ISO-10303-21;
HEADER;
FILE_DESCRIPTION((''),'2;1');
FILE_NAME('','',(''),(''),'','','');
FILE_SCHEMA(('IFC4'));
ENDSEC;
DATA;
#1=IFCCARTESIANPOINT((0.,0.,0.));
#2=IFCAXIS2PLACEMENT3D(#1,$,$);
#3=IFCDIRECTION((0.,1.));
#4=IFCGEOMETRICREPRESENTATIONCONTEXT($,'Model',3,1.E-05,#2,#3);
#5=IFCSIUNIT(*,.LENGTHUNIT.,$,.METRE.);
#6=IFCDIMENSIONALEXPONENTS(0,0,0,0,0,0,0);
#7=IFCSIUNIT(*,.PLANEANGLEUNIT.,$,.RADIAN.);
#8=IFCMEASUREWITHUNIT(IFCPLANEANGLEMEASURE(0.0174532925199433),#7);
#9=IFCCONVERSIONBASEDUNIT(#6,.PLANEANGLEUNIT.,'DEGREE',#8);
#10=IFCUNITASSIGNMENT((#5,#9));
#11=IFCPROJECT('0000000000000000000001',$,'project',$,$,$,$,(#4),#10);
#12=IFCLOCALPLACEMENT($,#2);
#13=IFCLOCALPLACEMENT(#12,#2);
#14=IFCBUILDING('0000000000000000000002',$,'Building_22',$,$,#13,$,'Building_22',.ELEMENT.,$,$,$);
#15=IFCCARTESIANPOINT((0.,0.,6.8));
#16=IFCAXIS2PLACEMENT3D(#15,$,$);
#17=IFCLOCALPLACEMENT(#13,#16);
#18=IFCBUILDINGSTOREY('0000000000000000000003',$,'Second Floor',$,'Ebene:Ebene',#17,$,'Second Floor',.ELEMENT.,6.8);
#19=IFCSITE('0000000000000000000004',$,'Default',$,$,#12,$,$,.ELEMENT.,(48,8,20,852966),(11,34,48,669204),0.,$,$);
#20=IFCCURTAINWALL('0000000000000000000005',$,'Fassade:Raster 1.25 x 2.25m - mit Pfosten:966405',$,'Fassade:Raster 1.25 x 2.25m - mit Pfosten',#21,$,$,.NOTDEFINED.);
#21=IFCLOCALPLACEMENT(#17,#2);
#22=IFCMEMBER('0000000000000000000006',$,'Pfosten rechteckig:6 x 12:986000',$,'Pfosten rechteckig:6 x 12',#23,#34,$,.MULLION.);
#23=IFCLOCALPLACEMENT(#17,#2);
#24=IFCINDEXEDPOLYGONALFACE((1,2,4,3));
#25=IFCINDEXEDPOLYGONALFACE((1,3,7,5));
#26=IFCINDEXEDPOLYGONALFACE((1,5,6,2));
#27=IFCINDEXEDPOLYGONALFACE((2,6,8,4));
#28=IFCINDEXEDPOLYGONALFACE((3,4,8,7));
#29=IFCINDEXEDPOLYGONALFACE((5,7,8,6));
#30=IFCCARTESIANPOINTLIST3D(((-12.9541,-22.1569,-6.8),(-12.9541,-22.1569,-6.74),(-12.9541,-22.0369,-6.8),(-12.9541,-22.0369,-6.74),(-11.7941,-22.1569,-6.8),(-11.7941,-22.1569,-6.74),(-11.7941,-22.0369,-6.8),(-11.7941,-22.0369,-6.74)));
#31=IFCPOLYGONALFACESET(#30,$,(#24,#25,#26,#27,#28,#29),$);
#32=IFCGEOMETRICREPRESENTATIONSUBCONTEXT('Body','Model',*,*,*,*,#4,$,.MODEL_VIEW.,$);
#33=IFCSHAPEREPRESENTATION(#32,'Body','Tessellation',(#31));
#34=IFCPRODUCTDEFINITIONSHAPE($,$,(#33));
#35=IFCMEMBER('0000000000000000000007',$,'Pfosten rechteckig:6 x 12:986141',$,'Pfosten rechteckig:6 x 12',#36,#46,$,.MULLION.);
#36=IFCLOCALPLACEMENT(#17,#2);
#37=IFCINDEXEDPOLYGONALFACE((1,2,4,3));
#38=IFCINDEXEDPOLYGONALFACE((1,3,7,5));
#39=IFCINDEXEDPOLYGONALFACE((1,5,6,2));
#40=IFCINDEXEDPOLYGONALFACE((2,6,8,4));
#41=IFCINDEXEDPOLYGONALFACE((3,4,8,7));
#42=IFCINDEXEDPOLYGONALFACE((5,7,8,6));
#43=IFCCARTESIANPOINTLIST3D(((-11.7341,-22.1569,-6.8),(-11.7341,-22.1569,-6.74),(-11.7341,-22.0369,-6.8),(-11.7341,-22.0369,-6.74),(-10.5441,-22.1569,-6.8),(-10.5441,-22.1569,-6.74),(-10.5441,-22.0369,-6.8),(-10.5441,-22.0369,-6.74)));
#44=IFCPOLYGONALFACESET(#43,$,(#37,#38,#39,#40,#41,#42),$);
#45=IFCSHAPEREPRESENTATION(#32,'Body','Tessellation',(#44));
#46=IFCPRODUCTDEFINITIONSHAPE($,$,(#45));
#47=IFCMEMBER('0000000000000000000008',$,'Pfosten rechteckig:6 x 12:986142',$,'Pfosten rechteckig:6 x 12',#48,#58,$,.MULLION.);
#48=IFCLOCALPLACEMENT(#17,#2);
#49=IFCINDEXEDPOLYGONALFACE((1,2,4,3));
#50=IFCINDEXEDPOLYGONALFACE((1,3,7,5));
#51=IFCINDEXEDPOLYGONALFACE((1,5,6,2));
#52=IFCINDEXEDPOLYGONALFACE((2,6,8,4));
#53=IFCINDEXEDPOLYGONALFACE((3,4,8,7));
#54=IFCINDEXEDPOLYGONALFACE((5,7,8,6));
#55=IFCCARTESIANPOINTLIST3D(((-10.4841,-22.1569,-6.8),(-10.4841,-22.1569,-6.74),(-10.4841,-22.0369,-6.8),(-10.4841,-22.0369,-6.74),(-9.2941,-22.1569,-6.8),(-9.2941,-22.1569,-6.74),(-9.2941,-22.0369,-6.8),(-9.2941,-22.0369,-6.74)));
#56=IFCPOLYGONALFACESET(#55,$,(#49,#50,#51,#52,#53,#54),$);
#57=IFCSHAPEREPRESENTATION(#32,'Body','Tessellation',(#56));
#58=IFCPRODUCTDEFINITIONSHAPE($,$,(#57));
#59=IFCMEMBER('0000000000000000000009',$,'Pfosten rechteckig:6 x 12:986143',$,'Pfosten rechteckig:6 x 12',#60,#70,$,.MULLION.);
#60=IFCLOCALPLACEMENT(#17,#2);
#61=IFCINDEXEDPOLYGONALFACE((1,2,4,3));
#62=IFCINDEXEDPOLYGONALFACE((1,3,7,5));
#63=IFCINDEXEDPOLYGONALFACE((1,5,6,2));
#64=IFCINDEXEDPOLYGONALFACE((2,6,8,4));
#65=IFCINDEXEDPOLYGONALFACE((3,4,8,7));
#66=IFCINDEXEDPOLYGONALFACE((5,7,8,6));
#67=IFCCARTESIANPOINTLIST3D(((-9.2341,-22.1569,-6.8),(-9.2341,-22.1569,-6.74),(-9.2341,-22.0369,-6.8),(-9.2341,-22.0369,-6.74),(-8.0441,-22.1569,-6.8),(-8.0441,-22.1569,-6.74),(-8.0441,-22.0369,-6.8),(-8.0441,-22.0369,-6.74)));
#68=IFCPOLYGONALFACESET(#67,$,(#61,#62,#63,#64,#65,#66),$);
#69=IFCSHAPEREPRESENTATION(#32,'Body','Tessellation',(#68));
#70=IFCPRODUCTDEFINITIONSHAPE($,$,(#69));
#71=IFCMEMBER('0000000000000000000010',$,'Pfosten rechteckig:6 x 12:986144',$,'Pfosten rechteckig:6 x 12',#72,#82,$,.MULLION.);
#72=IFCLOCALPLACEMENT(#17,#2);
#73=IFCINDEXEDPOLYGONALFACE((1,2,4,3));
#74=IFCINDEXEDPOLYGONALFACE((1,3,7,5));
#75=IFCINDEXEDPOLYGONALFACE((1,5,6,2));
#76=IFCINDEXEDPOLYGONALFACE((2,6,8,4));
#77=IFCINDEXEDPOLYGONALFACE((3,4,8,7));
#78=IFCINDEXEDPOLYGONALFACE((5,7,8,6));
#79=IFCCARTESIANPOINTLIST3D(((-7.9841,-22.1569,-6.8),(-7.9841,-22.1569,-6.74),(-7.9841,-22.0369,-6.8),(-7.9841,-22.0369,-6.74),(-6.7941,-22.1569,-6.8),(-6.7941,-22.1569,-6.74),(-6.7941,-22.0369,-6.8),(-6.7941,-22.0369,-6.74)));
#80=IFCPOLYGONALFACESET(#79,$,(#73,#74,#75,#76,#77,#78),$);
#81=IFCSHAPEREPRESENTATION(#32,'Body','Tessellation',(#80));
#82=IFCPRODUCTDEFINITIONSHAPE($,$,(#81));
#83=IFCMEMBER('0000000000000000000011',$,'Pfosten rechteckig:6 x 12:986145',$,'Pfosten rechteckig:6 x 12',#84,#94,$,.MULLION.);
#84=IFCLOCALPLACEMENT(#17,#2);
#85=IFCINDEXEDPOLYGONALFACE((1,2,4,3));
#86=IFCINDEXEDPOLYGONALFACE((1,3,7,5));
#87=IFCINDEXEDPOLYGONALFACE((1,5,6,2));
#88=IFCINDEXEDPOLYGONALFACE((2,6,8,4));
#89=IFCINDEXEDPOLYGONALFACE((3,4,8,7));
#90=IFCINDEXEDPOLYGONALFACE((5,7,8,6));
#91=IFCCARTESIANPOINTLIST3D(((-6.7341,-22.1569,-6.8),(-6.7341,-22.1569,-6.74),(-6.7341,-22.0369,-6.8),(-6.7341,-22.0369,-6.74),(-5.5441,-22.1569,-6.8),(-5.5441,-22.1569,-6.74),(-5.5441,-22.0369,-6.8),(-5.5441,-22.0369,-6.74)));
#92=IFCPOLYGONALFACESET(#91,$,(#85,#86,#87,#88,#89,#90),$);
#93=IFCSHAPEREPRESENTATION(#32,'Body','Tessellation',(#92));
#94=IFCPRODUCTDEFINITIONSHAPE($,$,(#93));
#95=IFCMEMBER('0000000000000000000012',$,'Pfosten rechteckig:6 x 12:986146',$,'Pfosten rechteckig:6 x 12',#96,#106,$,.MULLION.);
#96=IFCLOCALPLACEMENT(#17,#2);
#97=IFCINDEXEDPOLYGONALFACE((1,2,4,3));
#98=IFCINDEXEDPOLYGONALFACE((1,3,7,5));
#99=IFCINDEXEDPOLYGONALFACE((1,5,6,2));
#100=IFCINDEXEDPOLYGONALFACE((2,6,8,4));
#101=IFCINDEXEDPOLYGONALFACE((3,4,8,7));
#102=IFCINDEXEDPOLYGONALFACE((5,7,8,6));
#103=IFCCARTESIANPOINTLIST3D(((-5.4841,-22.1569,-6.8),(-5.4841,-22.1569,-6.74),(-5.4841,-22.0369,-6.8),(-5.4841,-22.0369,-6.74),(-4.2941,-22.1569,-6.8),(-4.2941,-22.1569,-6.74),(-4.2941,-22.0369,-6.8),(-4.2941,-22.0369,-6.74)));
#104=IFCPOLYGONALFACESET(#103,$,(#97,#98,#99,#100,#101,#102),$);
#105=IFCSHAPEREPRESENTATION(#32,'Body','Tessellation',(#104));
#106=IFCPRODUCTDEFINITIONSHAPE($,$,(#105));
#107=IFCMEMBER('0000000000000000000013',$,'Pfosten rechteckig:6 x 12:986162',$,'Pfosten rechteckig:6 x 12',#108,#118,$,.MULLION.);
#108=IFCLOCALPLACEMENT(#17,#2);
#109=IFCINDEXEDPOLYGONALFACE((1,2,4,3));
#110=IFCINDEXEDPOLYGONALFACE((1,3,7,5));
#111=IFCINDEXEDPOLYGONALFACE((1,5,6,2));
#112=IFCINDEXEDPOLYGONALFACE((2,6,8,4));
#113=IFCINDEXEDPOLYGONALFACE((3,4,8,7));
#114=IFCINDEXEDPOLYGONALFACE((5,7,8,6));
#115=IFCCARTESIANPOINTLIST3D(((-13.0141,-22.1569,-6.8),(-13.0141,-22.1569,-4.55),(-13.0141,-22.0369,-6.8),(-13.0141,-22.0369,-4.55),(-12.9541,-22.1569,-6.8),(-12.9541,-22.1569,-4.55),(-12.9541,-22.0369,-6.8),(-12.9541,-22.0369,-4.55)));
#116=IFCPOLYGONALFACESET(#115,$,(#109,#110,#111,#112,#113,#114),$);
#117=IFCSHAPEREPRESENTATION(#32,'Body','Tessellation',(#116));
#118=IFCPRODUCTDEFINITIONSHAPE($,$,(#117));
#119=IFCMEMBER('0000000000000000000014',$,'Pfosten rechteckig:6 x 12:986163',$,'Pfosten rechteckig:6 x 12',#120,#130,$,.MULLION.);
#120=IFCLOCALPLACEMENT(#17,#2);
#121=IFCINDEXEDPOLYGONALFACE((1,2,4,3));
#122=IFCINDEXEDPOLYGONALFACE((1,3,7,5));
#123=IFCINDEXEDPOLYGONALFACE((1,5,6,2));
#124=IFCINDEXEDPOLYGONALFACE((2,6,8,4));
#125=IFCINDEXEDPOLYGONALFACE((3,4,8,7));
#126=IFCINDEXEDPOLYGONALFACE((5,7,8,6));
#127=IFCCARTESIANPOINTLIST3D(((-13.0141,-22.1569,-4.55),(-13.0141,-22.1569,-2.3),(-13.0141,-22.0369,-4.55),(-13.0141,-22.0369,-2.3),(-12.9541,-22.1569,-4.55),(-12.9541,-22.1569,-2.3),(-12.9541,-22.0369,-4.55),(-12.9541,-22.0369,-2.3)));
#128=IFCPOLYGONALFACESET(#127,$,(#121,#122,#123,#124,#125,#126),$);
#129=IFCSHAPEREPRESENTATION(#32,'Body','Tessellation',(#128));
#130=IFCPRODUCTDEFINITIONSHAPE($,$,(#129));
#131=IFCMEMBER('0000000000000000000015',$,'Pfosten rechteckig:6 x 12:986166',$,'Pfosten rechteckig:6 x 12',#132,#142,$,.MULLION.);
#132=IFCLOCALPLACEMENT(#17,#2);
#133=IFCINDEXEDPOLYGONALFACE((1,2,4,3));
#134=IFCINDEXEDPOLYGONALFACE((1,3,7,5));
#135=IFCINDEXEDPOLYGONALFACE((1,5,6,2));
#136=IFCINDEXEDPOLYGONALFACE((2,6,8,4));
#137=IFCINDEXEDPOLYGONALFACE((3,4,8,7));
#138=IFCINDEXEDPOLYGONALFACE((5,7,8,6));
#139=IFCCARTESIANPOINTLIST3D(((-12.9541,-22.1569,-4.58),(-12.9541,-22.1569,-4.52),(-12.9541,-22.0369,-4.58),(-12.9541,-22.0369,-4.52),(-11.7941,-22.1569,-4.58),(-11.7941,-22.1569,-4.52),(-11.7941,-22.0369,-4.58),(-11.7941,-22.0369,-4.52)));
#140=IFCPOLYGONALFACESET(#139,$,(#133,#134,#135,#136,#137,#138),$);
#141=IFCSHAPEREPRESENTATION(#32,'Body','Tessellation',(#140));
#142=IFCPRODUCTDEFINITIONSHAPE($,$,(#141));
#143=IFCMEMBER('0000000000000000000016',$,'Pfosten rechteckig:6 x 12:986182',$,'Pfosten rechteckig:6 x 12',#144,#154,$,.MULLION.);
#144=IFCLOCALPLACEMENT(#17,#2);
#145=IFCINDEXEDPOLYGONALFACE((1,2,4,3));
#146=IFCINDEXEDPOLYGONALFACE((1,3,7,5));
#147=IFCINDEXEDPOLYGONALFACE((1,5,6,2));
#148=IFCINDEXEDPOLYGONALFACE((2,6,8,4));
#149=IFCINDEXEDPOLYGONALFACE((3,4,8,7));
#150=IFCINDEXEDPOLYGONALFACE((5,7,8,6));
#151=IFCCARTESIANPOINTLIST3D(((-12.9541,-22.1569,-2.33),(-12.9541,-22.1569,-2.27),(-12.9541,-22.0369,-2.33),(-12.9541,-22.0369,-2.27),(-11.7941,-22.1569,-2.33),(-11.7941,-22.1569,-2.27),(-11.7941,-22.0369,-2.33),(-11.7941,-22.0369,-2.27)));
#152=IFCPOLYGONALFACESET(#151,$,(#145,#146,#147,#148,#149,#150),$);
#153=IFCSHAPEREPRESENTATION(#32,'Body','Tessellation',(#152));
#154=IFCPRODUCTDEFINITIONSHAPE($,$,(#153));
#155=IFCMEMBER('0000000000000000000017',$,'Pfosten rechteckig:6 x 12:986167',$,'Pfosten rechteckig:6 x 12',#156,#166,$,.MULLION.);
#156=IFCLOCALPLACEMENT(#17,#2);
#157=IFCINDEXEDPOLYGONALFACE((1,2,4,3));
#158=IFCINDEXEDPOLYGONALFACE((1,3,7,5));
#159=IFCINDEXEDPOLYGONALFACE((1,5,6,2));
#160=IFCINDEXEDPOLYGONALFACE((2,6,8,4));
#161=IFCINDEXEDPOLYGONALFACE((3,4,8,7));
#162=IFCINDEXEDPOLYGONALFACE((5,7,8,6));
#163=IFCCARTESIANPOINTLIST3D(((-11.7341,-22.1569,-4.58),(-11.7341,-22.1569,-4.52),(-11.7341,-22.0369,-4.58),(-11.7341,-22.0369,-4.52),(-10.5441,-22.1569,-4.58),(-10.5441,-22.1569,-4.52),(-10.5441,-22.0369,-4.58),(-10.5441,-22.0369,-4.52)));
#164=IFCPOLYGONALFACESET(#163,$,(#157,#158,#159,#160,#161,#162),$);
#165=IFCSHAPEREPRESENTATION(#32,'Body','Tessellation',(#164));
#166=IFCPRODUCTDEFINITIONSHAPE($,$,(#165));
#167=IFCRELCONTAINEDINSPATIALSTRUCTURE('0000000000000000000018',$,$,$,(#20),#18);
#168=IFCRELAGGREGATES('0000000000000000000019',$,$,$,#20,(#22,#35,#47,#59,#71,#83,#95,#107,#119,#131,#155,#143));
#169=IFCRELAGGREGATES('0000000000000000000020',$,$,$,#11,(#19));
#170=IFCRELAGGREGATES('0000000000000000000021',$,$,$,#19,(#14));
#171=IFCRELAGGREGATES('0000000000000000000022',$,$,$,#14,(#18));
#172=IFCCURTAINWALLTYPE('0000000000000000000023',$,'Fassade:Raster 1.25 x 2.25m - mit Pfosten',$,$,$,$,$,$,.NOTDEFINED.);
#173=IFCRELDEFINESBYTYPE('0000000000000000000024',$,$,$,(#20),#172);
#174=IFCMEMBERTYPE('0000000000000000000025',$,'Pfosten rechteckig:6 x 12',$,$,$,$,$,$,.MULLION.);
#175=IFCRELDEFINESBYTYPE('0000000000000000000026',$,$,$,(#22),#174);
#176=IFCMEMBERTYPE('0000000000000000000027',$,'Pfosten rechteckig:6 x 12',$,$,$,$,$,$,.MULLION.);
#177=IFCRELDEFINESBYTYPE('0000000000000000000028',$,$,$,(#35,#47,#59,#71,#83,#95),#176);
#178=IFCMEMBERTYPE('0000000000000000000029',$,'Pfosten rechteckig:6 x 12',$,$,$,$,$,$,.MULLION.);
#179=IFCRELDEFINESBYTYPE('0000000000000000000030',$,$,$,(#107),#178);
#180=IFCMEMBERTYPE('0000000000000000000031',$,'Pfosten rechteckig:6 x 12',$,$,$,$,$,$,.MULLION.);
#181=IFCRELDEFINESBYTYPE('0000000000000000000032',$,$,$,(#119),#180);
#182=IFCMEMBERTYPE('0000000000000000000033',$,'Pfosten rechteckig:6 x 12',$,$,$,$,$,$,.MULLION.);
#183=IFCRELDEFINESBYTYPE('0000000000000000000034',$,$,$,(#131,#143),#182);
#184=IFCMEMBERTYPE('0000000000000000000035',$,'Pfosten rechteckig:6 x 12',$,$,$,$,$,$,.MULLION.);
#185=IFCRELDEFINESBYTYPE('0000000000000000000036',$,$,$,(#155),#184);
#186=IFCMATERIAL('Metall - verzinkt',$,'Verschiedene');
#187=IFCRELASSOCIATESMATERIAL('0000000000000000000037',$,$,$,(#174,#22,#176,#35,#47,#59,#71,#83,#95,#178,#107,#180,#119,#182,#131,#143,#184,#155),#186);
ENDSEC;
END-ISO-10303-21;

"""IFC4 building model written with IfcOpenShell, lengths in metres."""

from ifc_helpers import new_model, entity, si_unit, converted_unit, direction, frame, origin, place, context, subcontext, project, spatial, indexed_curve, outline, extrude, source, transform, mapped, material, type_object, type_shapes, element, aggregate, save


model = new_model("IFC4")

# Units and contexts
model_context = context("Model", 3, precision=1e-05, world=origin(), true_north=direction((0.0, 1.0)))
body_context = subcontext(model_context, "Body", "Model", "MODEL_VIEW")
ifc_project = project(units=[si_unit("LENGTHUNIT", "METRE"), converted_unit("PLANEANGLEUNIT", "DEGREE", entity("IfcPlaneAngleMeasure", 0.0174532925199433), si_unit("PLANEANGLEUNIT", "RADIAN"), dimensions=[0, 0, 0, 0, 0, 0, 0])], contexts=[model_context])

# Site, building, storey
site_placement = place(None, origin())
site = spatial("IfcSite", under=ifc_project, at=site_placement, Name="Default", CompositionType="ELEMENT", RefLatitude=(48, 8, 20, 852966), RefLongitude=(11, 34, 48, 669204), RefElevation=0.0)
building_placement = place(site_placement, origin())
building = spatial("IfcBuilding", under=site, at=building_placement, Name="Building_22", LongName="Building_22", CompositionType="ELEMENT")
storey_placement = place(building_placement, frame((0.0, 0.0, 6.8)))
storey = spatial("IfcBuildingStorey", under=building, at=storey_placement, Name="Second Floor", ObjectType="Ebene:Ebene", LongName="Second Floor", CompositionType="ELEMENT", Elevation=6.8)

# Curtain wall, members
curtain_wall_type = type_object("IfcCurtainWallType", Name="Fassade:Raster 1.25 x 2.25m - mit Pfosten", PredefinedType="NOTDEFINED")
curtain_wall_placement = place(storey_placement, frame((0.0, 0.0, -6.8)))
curtain_wall = element("IfcCurtainWall", 1, at=curtain_wall_placement, inside=storey, type_object=curtain_wall_type, Name="Fassade:Raster 1.25 x 2.25m - mit Pfosten:966405", ObjectType="Fassade:Raster 1.25 x 2.25m - mit Pfosten", PredefinedType="NOTDEFINED")
ifc_material_1 = material(Name="Metall - verzinkt", Category="Verschiedene")
member_type_1 = type_object("IfcMemberType", Name="Pfosten rechteckig:6 x 12", PredefinedType="MULLION", material=ifc_material_1)
shared_shape_1 = source(origin(), body_context, "Body", "SweptSolid", [
    extrude(outline(indexed_curve([(-0.03, -0.06), (0.03, -0.06), (0.03, 0.06), (-0.03, 0.06), (-0.03, -0.06)], self_intersect=False)), frame((-0.03, 0.0, -1.16), z_axis=(0.0, 0.0, 1.0), x_axis=(-1.0, 0.0, 0.0)), (0.0, 0.0, 1.0), 1.16),
])
type_shapes(member_type_1, [shared_shape_1])
member_1_placement = place(curtain_wall_placement, frame((-12.9541, -22.0969, 0.0), z_axis=(-1.0, 0.0, 0.0), x_axis=(0.0, 0.0, -1.0)))
member_1 = element("IfcMember", 2, at=member_1_placement, type_object=member_type_1, material=ifc_material_1, Name="Pfosten rechteckig:6 x 12:986000", ObjectType="Pfosten rechteckig:6 x 12", PredefinedType="MULLION", context=body_context, shape_type="MappedRepresentation", body=[
    mapped(shared_shape_1, transform((0.0, 0.0, 0.0), scale=1.0)),
])
member_type_2 = type_object("IfcMemberType", Name="Pfosten rechteckig:6 x 12", PredefinedType="MULLION", material=ifc_material_1)
shared_shape_2 = source(origin(), body_context, "Body", "SweptSolid", [
    extrude(outline(indexed_curve([(-0.03, -0.06), (0.03, -0.06), (0.03, 0.06), (-0.03, 0.06), (-0.03, -0.06)], self_intersect=False)), frame((-0.03, 0.0, -1.19), z_axis=(0.0, 0.0, 1.0), x_axis=(-1.0, 0.0, 0.0)), (0.0, 0.0, 1.0), 1.19),
])
type_shapes(member_type_2, [shared_shape_2])
member_2_placement = place(curtain_wall_placement, frame((-11.7341, -22.0969, 0.0), z_axis=(-1.0, 0.0, 0.0), x_axis=(0.0, 0.0, -1.0)))
member_2 = element("IfcMember", 3, at=member_2_placement, type_object=member_type_2, material=ifc_material_1, Name="Pfosten rechteckig:6 x 12:986141", ObjectType="Pfosten rechteckig:6 x 12", PredefinedType="MULLION", context=body_context, shape_type="MappedRepresentation", body=[
    mapped(shared_shape_2, transform((0.0, 0.0, 0.0), scale=1.0)),
])
member_3_placement = place(curtain_wall_placement, frame((-10.4841, -22.0969, 0.0), z_axis=(-1.0, 0.0, 0.0), x_axis=(0.0, 0.0, -1.0)))
member_3 = element("IfcMember", 4, at=member_3_placement, type_object=member_type_2, material=ifc_material_1, Name="Pfosten rechteckig:6 x 12:986142", ObjectType="Pfosten rechteckig:6 x 12", PredefinedType="MULLION", context=body_context, shape_type="MappedRepresentation", body=[
    mapped(shared_shape_2, transform((0.0, 0.0, 0.0), scale=1.0)),
])
member_4_placement = place(curtain_wall_placement, frame((-9.2341, -22.0969, 0.0), z_axis=(-1.0, 0.0, 0.0), x_axis=(0.0, 0.0, -1.0)))
member_4 = element("IfcMember", 5, at=member_4_placement, type_object=member_type_2, material=ifc_material_1, Name="Pfosten rechteckig:6 x 12:986143", ObjectType="Pfosten rechteckig:6 x 12", PredefinedType="MULLION", context=body_context, shape_type="MappedRepresentation", body=[
    mapped(shared_shape_2, transform((0.0, 0.0, 0.0), scale=1.0)),
])
member_5_placement = place(curtain_wall_placement, frame((-7.9841, -22.0969, 0.0), z_axis=(-1.0, 0.0, 0.0), x_axis=(0.0, 0.0, -1.0)))
member_5 = element("IfcMember", 6, at=member_5_placement, type_object=member_type_2, material=ifc_material_1, Name="Pfosten rechteckig:6 x 12:986144", ObjectType="Pfosten rechteckig:6 x 12", PredefinedType="MULLION", context=body_context, shape_type="MappedRepresentation", body=[
    mapped(shared_shape_2, transform((0.0, 0.0, 0.0), scale=1.0)),
])
member_6_placement = place(curtain_wall_placement, frame((-6.7341, -22.0969, 0.0), z_axis=(-1.0, 0.0, 0.0), x_axis=(0.0, 0.0, -1.0)))
member_6 = element("IfcMember", 7, at=member_6_placement, type_object=member_type_2, material=ifc_material_1, Name="Pfosten rechteckig:6 x 12:986145", ObjectType="Pfosten rechteckig:6 x 12", PredefinedType="MULLION", context=body_context, shape_type="MappedRepresentation", body=[
    mapped(shared_shape_2, transform((0.0, 0.0, 0.0), scale=1.0)),
])
member_7_placement = place(curtain_wall_placement, frame((-5.4841, -22.0969, 0.0), z_axis=(-1.0, 0.0, 0.0), x_axis=(0.0, 0.0, -1.0)))
member_7 = element("IfcMember", 8, at=member_7_placement, type_object=member_type_2, material=ifc_material_1, Name="Pfosten rechteckig:6 x 12:986146", ObjectType="Pfosten rechteckig:6 x 12", PredefinedType="MULLION", context=body_context, shape_type="MappedRepresentation", body=[
    mapped(shared_shape_2, transform((0.0, 0.0, 0.0), scale=1.0)),
])
member_type_3 = type_object("IfcMemberType", Name="Pfosten rechteckig:6 x 12", PredefinedType="MULLION", material=ifc_material_1)
shared_shape_3 = source(origin(), body_context, "Body", "SweptSolid", [
    extrude(outline(indexed_curve([(-0.03, -0.06), (0.03, -0.06), (0.03, 0.06), (-0.03, 0.06), (-0.03, -0.06)], self_intersect=False)), frame((-0.03, 0.0, -2.25), z_axis=(0.0, 0.0, 1.0), x_axis=(-1.0, 0.0, 0.0)), (0.0, 0.0, 1.0), 2.25),
])
type_shapes(member_type_3, [shared_shape_3])
member_8_placement = place(curtain_wall_placement, frame((-13.0141, -22.0969, 2.25), z_axis=(0.0, 0.0, 1.0), x_axis=(-1.0, 0.0, 0.0)))
member_8 = element("IfcMember", 9, at=member_8_placement, type_object=member_type_3, material=ifc_material_1, Name="Pfosten rechteckig:6 x 12:986162", ObjectType="Pfosten rechteckig:6 x 12", PredefinedType="MULLION", context=body_context, shape_type="MappedRepresentation", body=[
    mapped(shared_shape_3, transform((0.0, 0.0, 0.0), scale=1.0)),
])
member_type_4 = type_object("IfcMemberType", Name="Pfosten rechteckig:6 x 12", PredefinedType="MULLION", material=ifc_material_1)
shared_shape_4 = source(origin(), body_context, "Body", "SweptSolid", [
    extrude(outline(indexed_curve([(-0.03, -0.06), (0.03, -0.06), (0.03, 0.06), (-0.03, 0.06), (-0.03, -0.06)], self_intersect=False)), frame((-0.03, 0.0, -2.25), z_axis=(0.0, 0.0, 1.0), x_axis=(-1.0, 0.0, 0.0)), (0.0, 0.0, 1.0), 2.25),
])
type_shapes(member_type_4, [shared_shape_4])
member_9_placement = place(curtain_wall_placement, frame((-13.0141, -22.0969, 4.5), z_axis=(0.0, 0.0, 1.0), x_axis=(-1.0, 0.0, 0.0)))
member_9 = element("IfcMember", 10, at=member_9_placement, type_object=member_type_4, material=ifc_material_1, Name="Pfosten rechteckig:6 x 12:986163", ObjectType="Pfosten rechteckig:6 x 12", PredefinedType="MULLION", context=body_context, shape_type="MappedRepresentation", body=[
    mapped(shared_shape_4, transform((0.0, 0.0, 0.0), scale=1.0)),
])
member_type_5 = type_object("IfcMemberType", Name="Pfosten rechteckig:6 x 12", PredefinedType="MULLION", material=ifc_material_1)
shared_shape_5 = source(origin(), body_context, "Body", "SweptSolid", [
    extrude(outline(indexed_curve([(-0.03, -0.06), (0.03, -0.06), (0.03, 0.06), (-0.03, 0.06), (-0.03, -0.06)], self_intersect=False)), frame((0.0, 0.0, -1.16), z_axis=(0.0, 0.0, 1.0), x_axis=(-1.0, 0.0, 0.0)), (0.0, 0.0, 1.0), 1.16),
])
type_shapes(member_type_5, [shared_shape_5])
member_10_placement = place(curtain_wall_placement, frame((-11.7941, -22.0969, 2.25), z_axis=(1.0, 0.0, 0.0), x_axis=(0.0, 0.0, 1.0)))
member_10 = element("IfcMember", 11, at=member_10_placement, type_object=member_type_5, material=ifc_material_1, Name="Pfosten rechteckig:6 x 12:986166", ObjectType="Pfosten rechteckig:6 x 12", PredefinedType="MULLION", context=body_context, shape_type="MappedRepresentation", body=[
    mapped(shared_shape_5, transform((0.0, 0.0, 0.0), scale=1.0)),
])
member_11_placement = place(curtain_wall_placement, frame((-11.7941, -22.0969, 4.5), z_axis=(1.0, 0.0, 0.0), x_axis=(0.0, 0.0, 1.0)))
member_11 = element("IfcMember", 12, at=member_11_placement, type_object=member_type_5, material=ifc_material_1, Name="Pfosten rechteckig:6 x 12:986182", ObjectType="Pfosten rechteckig:6 x 12", PredefinedType="MULLION", context=body_context, shape_type="MappedRepresentation", body=[
    mapped(shared_shape_5, transform((0.0, 0.0, 0.0), scale=1.0)),
])
member_type_6 = type_object("IfcMemberType", Name="Pfosten rechteckig:6 x 12", PredefinedType="MULLION", material=ifc_material_1)
shared_shape_6 = source(origin(), body_context, "Body", "SweptSolid", [
    extrude(outline(indexed_curve([(-0.03, -0.06), (0.03, -0.06), (0.03, 0.06), (-0.03, 0.06), (-0.03, -0.06)], self_intersect=False)), frame((0.0, 0.0, -1.19), z_axis=(0.0, 0.0, 1.0), x_axis=(-1.0, 0.0, 0.0)), (0.0, 0.0, 1.0), 1.19),
])
type_shapes(member_type_6, [shared_shape_6])
member_12_placement = place(curtain_wall_placement, frame((-10.5441, -22.0969, 2.25), z_axis=(1.0, 0.0, 0.0), x_axis=(0.0, 0.0, 1.0)))
member_12 = element("IfcMember", 13, at=member_12_placement, type_object=member_type_6, material=ifc_material_1, Name="Pfosten rechteckig:6 x 12:986167", ObjectType="Pfosten rechteckig:6 x 12", PredefinedType="MULLION", context=body_context, shape_type="MappedRepresentation", body=[
    mapped(shared_shape_6, transform((0.0, 0.0, 0.0), scale=1.0)),
])
aggregate(curtain_wall, [member_1, member_2, member_3, member_4, member_5, member_6, member_7, member_8, member_9, member_10, member_12, member_11])

save(model, "model.ifc")
